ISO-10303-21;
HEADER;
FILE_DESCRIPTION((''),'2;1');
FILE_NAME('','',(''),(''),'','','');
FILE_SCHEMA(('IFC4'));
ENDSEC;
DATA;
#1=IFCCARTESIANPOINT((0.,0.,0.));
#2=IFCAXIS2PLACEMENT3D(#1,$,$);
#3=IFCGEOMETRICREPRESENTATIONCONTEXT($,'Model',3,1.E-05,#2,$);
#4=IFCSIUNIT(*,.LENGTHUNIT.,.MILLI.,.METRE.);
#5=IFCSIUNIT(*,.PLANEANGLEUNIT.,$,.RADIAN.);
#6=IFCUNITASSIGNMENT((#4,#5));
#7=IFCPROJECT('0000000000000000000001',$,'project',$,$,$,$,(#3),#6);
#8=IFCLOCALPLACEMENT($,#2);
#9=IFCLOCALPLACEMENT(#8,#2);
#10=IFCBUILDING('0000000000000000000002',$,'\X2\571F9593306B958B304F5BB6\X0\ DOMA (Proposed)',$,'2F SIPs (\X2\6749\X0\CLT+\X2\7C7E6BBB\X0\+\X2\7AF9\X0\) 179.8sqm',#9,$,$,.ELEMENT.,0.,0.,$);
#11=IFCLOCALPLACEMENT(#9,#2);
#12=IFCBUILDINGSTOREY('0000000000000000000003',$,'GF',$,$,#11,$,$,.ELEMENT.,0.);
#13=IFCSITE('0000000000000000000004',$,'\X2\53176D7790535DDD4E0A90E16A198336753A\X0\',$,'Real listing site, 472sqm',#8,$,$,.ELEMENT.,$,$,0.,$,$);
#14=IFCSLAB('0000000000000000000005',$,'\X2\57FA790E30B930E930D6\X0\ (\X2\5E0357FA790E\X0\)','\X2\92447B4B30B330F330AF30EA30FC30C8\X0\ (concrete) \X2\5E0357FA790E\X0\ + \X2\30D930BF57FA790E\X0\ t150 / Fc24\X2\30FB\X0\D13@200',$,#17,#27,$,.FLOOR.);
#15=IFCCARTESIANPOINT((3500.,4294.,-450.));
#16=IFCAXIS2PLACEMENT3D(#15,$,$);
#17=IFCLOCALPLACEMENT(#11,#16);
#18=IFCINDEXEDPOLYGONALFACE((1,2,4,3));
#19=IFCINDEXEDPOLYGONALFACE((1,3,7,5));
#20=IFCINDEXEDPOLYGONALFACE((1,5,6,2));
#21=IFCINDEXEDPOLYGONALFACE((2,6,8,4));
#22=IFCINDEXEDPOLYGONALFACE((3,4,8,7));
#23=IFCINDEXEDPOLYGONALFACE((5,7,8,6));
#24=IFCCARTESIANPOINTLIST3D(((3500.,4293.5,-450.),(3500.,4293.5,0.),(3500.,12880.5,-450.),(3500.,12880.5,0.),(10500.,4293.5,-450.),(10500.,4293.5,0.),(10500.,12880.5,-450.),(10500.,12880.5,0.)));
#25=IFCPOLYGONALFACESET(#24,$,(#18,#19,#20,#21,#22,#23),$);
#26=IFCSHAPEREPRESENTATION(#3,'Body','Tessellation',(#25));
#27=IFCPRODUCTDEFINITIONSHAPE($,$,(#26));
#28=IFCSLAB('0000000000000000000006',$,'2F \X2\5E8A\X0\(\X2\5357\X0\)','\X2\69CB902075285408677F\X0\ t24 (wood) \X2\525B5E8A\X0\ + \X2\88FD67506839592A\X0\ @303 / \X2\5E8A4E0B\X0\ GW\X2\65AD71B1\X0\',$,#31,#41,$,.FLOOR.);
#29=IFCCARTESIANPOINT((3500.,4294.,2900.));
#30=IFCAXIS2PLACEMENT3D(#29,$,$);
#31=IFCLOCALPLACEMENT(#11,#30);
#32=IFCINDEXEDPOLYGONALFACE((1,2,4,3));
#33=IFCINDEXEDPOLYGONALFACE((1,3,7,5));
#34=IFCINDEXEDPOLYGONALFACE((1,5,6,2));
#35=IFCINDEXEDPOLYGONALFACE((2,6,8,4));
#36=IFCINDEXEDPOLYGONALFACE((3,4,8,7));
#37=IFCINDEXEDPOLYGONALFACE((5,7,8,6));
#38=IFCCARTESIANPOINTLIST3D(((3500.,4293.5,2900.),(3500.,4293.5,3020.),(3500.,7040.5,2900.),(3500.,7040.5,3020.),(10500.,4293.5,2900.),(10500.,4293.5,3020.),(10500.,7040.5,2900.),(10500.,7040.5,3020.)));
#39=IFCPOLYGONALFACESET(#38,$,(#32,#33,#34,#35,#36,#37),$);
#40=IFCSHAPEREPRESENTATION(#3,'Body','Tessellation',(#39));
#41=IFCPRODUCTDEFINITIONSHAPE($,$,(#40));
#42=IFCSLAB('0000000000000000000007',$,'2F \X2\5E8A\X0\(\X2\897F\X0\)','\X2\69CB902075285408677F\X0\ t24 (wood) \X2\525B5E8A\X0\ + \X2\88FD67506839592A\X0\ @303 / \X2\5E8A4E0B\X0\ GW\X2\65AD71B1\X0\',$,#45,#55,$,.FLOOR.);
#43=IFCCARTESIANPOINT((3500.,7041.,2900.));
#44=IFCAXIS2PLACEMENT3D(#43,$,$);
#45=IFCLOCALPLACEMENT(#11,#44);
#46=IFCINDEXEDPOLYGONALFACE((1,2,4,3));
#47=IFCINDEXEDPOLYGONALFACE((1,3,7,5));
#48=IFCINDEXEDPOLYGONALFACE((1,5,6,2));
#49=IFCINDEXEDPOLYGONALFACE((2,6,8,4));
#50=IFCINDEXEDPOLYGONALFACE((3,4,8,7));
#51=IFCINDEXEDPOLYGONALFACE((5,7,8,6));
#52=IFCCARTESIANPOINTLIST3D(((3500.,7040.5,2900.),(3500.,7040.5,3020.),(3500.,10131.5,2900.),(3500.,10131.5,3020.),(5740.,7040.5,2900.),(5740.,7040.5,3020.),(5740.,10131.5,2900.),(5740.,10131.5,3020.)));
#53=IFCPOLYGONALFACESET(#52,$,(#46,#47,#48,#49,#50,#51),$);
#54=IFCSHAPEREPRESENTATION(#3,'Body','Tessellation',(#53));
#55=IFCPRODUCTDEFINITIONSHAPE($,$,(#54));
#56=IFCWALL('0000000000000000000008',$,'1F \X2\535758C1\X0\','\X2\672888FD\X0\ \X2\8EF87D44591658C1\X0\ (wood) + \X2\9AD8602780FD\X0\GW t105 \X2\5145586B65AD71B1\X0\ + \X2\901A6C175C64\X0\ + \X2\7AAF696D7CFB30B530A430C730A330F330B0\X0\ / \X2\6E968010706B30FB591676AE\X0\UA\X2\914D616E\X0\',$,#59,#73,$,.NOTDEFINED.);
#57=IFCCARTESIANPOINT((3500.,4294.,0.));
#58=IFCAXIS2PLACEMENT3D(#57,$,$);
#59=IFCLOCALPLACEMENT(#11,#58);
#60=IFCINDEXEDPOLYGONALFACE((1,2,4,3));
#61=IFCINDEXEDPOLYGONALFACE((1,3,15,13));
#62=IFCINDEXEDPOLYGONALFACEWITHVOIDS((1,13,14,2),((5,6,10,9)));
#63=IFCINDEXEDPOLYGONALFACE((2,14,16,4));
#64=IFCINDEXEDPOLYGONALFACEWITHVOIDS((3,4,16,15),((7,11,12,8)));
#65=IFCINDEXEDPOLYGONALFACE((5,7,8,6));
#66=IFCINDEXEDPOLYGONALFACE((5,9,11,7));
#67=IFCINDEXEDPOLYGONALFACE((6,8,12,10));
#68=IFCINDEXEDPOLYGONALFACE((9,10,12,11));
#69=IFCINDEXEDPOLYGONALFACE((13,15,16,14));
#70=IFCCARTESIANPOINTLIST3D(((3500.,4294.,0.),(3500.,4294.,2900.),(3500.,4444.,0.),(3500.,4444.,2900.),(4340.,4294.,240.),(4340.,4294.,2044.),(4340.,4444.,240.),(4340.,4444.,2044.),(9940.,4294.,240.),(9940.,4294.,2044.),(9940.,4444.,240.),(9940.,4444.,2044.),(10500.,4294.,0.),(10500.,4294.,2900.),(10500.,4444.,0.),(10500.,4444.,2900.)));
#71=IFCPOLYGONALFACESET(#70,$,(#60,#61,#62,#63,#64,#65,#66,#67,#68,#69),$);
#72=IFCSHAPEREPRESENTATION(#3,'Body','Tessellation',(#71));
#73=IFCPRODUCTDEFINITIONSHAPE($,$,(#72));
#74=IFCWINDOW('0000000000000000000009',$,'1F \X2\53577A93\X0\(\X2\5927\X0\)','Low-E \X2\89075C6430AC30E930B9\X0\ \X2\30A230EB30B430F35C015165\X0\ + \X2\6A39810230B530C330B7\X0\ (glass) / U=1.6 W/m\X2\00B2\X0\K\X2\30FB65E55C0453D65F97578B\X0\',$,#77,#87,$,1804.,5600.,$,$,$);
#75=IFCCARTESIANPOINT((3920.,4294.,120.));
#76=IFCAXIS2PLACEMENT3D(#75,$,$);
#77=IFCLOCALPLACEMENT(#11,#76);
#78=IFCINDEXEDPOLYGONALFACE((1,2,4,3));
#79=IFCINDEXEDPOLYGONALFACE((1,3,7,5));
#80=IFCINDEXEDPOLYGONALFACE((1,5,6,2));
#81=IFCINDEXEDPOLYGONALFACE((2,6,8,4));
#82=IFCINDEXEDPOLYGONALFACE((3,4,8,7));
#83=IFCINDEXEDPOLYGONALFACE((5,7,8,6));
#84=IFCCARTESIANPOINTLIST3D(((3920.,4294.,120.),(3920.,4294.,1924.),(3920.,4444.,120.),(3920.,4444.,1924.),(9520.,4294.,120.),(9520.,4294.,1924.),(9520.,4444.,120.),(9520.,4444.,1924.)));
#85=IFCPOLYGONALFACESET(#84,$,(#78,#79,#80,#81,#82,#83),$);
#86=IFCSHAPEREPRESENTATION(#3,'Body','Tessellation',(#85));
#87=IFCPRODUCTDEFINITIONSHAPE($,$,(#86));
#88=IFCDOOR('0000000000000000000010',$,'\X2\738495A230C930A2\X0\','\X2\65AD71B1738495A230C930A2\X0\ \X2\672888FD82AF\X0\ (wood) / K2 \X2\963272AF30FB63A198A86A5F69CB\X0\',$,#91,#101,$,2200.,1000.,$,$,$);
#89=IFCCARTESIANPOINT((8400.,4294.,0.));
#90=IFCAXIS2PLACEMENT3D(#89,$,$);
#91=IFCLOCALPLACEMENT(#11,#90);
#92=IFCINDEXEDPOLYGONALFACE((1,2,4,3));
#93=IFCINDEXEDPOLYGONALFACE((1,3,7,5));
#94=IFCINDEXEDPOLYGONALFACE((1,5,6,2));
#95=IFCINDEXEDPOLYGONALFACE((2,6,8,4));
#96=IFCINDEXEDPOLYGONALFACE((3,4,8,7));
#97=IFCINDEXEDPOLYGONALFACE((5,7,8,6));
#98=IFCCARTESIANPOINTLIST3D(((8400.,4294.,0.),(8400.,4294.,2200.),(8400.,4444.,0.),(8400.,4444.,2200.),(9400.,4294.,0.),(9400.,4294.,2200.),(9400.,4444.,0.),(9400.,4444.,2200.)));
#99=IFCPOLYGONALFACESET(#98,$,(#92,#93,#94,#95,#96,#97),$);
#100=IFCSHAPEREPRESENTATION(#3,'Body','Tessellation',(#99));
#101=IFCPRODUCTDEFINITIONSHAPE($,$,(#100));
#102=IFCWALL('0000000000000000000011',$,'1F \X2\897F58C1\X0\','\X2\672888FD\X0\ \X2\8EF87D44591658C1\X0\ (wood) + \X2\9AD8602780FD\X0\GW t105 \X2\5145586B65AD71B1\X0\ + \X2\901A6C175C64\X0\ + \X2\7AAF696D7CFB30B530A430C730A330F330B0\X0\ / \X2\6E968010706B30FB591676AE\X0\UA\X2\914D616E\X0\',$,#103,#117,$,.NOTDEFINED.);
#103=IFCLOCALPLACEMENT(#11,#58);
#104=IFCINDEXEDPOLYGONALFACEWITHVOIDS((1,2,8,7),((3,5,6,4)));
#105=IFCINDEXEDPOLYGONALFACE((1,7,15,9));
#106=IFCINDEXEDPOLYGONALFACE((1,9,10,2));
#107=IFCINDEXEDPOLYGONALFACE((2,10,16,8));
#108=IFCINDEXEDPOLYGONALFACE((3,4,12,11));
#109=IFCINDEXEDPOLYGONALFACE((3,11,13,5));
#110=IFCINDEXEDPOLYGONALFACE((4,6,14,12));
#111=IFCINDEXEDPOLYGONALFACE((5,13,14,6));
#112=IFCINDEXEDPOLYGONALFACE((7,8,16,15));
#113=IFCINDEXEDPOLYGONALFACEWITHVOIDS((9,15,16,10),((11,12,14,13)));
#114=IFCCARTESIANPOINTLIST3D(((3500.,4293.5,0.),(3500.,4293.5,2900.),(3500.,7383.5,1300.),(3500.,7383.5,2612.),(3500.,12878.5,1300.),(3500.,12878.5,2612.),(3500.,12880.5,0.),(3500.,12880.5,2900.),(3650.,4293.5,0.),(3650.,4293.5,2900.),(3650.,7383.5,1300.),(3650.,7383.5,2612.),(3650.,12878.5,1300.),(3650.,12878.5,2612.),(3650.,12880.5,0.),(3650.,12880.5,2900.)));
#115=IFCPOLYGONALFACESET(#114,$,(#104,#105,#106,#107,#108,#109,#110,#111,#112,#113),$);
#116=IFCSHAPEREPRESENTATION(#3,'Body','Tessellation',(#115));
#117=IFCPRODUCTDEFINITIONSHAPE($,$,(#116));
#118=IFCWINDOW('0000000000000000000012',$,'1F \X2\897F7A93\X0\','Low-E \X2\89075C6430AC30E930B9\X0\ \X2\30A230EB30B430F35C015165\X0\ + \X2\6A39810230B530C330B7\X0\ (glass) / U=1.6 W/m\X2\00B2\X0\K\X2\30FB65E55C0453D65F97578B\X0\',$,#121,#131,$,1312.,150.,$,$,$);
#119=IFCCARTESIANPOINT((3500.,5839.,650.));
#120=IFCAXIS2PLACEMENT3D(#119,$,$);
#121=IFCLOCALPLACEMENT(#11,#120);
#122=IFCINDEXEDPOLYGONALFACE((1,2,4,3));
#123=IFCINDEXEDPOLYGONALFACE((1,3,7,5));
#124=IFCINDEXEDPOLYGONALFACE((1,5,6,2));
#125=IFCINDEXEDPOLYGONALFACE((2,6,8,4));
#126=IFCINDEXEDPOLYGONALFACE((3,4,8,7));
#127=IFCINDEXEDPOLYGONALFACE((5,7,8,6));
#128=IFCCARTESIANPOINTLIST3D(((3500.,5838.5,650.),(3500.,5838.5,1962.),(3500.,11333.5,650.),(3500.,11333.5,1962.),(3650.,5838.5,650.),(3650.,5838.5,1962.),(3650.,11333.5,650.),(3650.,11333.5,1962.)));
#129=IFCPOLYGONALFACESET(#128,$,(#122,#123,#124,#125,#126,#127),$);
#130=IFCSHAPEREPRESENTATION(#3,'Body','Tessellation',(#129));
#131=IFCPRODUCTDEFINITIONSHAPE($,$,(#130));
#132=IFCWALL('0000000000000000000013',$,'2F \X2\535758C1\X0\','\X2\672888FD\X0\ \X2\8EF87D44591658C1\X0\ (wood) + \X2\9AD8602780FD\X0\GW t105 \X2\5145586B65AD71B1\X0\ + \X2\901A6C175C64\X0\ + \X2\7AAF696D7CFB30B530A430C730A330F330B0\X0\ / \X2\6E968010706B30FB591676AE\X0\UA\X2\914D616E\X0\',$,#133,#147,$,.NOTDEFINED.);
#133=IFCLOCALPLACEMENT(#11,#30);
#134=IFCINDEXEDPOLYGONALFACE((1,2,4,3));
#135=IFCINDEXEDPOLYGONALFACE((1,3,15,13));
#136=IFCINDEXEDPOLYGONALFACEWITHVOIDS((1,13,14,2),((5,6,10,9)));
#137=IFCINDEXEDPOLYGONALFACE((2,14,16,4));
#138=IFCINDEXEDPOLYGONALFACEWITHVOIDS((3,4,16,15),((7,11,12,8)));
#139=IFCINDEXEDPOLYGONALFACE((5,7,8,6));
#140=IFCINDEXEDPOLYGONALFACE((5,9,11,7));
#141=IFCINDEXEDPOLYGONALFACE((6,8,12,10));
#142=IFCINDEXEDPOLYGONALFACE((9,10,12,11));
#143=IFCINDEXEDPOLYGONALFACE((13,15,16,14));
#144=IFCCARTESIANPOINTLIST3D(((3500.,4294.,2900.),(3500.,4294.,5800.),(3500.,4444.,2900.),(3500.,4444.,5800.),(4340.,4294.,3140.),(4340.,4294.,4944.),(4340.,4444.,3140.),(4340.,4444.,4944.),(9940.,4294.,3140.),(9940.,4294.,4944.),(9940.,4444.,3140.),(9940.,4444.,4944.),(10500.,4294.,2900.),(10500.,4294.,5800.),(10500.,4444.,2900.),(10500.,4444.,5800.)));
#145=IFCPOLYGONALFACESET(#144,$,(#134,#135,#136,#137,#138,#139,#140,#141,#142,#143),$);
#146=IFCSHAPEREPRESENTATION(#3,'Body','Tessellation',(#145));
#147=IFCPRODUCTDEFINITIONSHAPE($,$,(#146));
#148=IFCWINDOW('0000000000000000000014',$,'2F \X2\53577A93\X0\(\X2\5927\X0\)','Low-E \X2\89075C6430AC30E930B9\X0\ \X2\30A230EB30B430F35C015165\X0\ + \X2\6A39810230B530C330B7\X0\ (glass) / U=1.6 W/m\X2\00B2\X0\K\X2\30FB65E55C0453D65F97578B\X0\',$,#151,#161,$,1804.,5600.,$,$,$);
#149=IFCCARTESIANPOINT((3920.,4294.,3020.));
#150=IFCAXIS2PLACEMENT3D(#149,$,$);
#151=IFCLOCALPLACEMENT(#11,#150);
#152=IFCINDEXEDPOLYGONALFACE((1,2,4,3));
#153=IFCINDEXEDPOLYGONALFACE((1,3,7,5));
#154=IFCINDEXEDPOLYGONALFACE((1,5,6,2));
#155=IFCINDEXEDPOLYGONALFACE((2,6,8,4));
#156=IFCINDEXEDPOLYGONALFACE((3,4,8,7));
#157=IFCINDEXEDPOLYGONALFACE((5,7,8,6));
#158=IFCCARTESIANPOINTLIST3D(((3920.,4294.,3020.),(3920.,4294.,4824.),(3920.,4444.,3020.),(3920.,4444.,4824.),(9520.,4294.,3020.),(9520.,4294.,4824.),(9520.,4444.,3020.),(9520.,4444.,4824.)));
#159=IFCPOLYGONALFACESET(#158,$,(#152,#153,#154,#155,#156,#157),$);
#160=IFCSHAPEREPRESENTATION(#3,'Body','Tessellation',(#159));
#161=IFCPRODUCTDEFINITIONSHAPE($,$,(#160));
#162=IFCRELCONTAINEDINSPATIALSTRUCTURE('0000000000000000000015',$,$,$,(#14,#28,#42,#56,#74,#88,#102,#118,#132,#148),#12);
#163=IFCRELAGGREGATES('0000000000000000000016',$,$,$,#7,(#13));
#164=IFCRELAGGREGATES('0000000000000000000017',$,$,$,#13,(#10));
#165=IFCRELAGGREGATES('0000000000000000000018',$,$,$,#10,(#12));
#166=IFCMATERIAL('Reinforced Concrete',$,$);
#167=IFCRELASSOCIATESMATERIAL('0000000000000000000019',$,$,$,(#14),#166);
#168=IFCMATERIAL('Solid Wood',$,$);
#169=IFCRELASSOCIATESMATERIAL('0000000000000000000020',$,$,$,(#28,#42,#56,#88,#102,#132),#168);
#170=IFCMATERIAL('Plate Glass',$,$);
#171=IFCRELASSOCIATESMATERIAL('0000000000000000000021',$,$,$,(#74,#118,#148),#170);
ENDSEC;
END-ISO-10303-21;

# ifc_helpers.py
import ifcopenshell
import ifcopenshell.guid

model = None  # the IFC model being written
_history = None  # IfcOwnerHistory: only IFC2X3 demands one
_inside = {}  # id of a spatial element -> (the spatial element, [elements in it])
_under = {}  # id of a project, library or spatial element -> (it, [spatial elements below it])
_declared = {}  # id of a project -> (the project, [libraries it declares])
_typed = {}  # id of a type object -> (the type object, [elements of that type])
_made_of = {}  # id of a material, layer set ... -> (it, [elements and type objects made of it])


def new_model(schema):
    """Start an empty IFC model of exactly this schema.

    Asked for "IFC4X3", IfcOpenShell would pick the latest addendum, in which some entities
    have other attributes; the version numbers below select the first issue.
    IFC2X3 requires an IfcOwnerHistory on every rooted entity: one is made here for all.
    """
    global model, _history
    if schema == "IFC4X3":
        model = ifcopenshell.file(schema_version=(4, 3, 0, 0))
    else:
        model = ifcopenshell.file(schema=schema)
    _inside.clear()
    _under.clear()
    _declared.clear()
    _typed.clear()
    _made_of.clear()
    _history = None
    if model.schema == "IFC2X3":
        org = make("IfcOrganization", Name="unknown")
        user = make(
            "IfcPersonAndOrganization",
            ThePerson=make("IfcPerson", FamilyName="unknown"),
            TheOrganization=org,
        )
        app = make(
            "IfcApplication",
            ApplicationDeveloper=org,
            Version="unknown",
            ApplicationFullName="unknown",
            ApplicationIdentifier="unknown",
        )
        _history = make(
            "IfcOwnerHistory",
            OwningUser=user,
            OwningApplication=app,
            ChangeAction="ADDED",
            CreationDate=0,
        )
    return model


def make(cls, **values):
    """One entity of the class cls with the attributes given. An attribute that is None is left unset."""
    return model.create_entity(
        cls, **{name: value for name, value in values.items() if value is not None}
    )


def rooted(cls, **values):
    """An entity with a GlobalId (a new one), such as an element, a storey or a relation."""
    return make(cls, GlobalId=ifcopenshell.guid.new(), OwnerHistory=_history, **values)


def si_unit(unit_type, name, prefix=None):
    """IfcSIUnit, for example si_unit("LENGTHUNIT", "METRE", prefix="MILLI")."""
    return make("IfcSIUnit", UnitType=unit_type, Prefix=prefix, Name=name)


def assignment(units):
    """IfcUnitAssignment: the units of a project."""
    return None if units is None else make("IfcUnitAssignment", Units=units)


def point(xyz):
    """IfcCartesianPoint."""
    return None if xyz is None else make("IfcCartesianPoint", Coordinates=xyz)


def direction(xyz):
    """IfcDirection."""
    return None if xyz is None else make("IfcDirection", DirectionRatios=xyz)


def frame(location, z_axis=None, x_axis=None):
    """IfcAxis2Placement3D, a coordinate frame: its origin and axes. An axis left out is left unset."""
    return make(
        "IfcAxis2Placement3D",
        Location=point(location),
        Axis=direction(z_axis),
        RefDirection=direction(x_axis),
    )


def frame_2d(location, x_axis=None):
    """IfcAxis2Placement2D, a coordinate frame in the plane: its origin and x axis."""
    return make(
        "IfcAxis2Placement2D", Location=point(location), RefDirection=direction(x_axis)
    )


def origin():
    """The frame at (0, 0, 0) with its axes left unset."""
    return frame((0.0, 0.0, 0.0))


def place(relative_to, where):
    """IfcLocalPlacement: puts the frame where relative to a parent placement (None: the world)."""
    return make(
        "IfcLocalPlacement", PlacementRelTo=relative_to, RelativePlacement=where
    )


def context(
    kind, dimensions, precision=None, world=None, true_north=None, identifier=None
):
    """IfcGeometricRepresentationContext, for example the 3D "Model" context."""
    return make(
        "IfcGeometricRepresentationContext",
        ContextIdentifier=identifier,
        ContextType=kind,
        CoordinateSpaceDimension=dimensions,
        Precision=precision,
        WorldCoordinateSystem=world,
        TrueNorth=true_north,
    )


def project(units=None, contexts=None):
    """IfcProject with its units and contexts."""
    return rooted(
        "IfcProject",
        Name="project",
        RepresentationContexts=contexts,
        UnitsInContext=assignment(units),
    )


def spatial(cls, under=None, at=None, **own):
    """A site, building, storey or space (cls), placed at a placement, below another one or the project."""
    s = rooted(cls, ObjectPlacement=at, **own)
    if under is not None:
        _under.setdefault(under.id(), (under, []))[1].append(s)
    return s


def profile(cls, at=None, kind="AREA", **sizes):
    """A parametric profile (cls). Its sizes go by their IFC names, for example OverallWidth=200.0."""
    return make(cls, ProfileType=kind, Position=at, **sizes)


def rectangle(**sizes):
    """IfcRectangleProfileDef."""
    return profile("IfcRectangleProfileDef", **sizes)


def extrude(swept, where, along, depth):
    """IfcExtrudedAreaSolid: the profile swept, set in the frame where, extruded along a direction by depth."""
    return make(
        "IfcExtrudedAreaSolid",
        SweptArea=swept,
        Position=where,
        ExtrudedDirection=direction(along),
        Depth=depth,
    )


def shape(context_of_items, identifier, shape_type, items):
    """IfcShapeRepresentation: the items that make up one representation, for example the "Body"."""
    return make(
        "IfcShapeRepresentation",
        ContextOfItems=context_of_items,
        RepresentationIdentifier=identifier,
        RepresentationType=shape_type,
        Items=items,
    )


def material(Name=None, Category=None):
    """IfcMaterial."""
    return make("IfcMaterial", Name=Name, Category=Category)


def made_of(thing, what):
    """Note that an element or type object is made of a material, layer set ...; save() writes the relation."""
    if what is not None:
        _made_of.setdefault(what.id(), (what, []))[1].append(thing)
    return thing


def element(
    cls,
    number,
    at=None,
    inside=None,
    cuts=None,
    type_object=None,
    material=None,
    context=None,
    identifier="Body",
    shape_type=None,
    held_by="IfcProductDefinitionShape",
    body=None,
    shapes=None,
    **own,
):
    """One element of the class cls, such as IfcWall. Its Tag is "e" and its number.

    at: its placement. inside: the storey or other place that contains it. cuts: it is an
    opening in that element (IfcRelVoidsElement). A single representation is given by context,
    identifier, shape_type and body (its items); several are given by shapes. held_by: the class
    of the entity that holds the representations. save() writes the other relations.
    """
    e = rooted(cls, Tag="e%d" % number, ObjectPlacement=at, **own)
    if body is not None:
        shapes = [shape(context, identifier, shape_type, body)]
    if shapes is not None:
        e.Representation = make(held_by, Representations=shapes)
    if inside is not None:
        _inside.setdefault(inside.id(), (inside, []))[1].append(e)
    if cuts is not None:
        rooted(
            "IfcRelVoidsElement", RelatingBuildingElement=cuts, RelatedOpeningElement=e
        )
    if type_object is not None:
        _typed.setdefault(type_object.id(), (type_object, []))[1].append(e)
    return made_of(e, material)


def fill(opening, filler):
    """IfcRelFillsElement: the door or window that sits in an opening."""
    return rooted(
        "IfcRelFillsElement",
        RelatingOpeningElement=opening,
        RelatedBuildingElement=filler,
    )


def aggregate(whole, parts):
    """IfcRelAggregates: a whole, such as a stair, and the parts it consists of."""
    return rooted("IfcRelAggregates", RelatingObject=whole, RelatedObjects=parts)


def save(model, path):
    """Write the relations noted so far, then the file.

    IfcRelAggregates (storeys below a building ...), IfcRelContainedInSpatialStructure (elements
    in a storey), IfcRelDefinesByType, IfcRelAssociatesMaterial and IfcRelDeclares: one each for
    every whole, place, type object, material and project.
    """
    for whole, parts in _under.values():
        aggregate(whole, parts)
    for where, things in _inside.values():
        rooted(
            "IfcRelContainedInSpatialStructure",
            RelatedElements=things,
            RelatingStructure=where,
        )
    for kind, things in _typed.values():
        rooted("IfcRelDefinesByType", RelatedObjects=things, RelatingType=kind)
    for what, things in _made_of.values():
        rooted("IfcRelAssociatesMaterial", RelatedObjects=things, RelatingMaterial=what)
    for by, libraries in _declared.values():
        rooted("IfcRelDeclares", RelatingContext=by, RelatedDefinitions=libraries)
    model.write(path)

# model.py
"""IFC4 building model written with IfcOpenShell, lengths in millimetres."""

from ifc_helpers import new_model, si_unit, frame, frame_2d, origin, place, context, project, spatial, rectangle, extrude, material, element, fill, save


model = new_model("IFC4")

# Units and contexts
model_context = context("Model", 3, precision=1e-05, world=origin())
ifc_project = project(units=[si_unit("LENGTHUNIT", "METRE", prefix="MILLI"), si_unit("PLANEANGLEUNIT", "RADIAN")], contexts=[model_context])

# Site, building, storey
site_placement = place(None, origin())
site = spatial("IfcSite", under=ifc_project, at=site_placement, Name="北海道川上郡標茶町", ObjectType="Real listing site, 472sqm", CompositionType="ELEMENT", RefElevation=0.0)
building_placement = place(site_placement, origin())
building = spatial("IfcBuilding", under=site, at=building_placement, Name="土間に開く家 DOMA (Proposed)", ObjectType="2F SIPs (杉CLT+籾殻+竹) 179.8sqm", CompositionType="ELEMENT", ElevationOfRefHeight=0.0, ElevationOfTerrain=0.0)
storey_placement = place(building_placement, origin())
storey = spatial("IfcBuildingStorey", under=building, at=storey_placement, Name="GF", CompositionType="ELEMENT", Elevation=0.0)

# Slabs
ifc_material_1 = material(Name="Reinforced Concrete")
slab_1_placement = place(storey_placement, frame((3500.0, 4294.0, -450.0)))
element("IfcSlab", 1, at=slab_1_placement, inside=storey, material=ifc_material_1, Name="基礎スラブ (布基礎)", Description="鉄筋コンクリート (concrete) 布基礎 + ベタ基礎 t150 / Fc24・D13@200", PredefinedType="FLOOR", context=model_context, shape_type="SweptSolid", body=[
    extrude(rectangle(XDim=7000.0, YDim=8587.0, at=frame_2d((3500.0, 4293.0))), frame((3500.0, 4294.0, -450.0)), (0.0, 0.0, 1.0), 450.0),
])
ifc_material_2 = material(Name="Solid Wood")
slab_2_placement = place(storey_placement, frame((3500.0, 4294.0, 2900.0)))
element("IfcSlab", 2, at=slab_2_placement, inside=storey, material=ifc_material_2, Name="2F 床(南)", Description="構造用合板 t24 (wood) 剛床 + 製材根太 @303 / 床下 GW断熱", PredefinedType="FLOOR", context=model_context, shape_type="SweptSolid", body=[
    extrude(rectangle(XDim=7000.0, YDim=2747.0, at=frame_2d((3500.0, 1373.0))), frame((3500.0, 4294.0, 2900.0)), (0.0, 0.0, 1.0), 120.0),
])
slab_3_placement = place(storey_placement, frame((3500.0, 7041.0, 2900.0)))
element("IfcSlab", 3, at=slab_3_placement, inside=storey, material=ifc_material_2, Name="2F 床(西)", Description="構造用合板 t24 (wood) 剛床 + 製材根太 @303 / 床下 GW断熱", PredefinedType="FLOOR", context=model_context, shape_type="SweptSolid", body=[
    extrude(rectangle(XDim=2240.0, YDim=3091.0, at=frame_2d((1120.0, 1545.0))), frame((3500.0, 7041.0, 2900.0)), (0.0, 0.0, 1.0), 120.0),
])

# Wall, openings, window, door
wall_1_placement = place(storey_placement, frame((3500.0, 4294.0, 0.0)))
wall_1 = element("IfcWall", 4, at=wall_1_placement, inside=storey, material=ifc_material_2, Name="1F 南壁", Description="木製 軸組外壁 (wood) + 高性能GW t105 充填断熱 + 通気層 + 窯業系サイディング / 準耐火・外皮UA配慮", PredefinedType="NOTDEFINED", context=model_context, shape_type="SweptSolid", body=[
    extrude(rectangle(XDim=7000.0, YDim=150.0, at=frame_2d((3500.0, 75.0))), frame((3500.0, 4294.0, 0.0)), (0.0, 0.0, 1.0), 2900.0),
])
opening_1_placement = place(storey_placement, frame((3920.0, 4294.0, 120.0)))
opening_1 = element("IfcOpeningElement", 5, at=opening_1_placement, cuts=wall_1, PredefinedType="NOTDEFINED", context=model_context, shape_type="SweptSolid", body=[
    extrude(rectangle(XDim=5600.0, YDim=150.0, at=frame_2d((2800.0, 75.0))), frame((3920.0, 4294.0, 120.0)), (0.0, 0.0, 1.0), 1804.0),
])
opening_2_placement = place(storey_placement, frame((8400.0, 4294.0, 0.0)))
opening_2 = element("IfcOpeningElement", 6, at=opening_2_placement, cuts=wall_1, PredefinedType="NOTDEFINED", context=model_context, shape_type="SweptSolid", body=[
    extrude(rectangle(XDim=1000.0, YDim=150.0, at=frame_2d((500.0, 75.0))), frame((8400.0, 4294.0, 0.0)), (0.0, 0.0, 1.0), 2200.0),
])
ifc_material_3 = material(Name="Plate Glass")
window_1_placement = place(storey_placement, frame((3920.0, 4294.0, 120.0)))
window_1 = element("IfcWindow", 7, at=window_1_placement, inside=storey, material=ifc_material_3, Name="1F 南窓(大)", Description="Low-E 複層ガラス アルゴン封入 + 樹脂サッシ (glass) / U=1.6 W/m²K・日射取得型", OverallHeight=1804.0, OverallWidth=5600.0, context=model_context, shape_type="SweptSolid", body=[
    extrude(rectangle(XDim=5600.0, YDim=150.0, at=frame_2d((2800.0, 75.0))), frame((3920.0, 4294.0, 120.0)), (0.0, 0.0, 1.0), 1804.0),
])
fill(opening_1, window_1)
door_placement = place(storey_placement, frame((8400.0, 4294.0, 0.0)))
door = element("IfcDoor", 8, at=door_placement, inside=storey, material=ifc_material_2, Name="玄関ドア", Description="断熱玄関ドア 木製芯 (wood) / K2 防犯・採風機構", OverallHeight=2200.0, OverallWidth=1000.0, context=model_context, shape_type="SweptSolid", body=[
    extrude(rectangle(XDim=1000.0, YDim=150.0, at=frame_2d((500.0, 75.0))), frame((8400.0, 4294.0, 0.0)), (0.0, 0.0, 1.0), 2200.0),
])
fill(opening_2, door)

# Walls, openings, windows
wall_2_placement = place(storey_placement, frame((3500.0, 4294.0, 0.0)))
wall_2 = element("IfcWall", 9, at=wall_2_placement, inside=storey, material=ifc_material_2, Name="1F 西壁", Description="木製 軸組外壁 (wood) + 高性能GW t105 充填断熱 + 通気層 + 窯業系サイディング / 準耐火・外皮UA配慮", PredefinedType="NOTDEFINED", context=model_context, shape_type="SweptSolid", body=[
    extrude(rectangle(XDim=150.0, YDim=8587.0, at=frame_2d((75.0, 4293.0))), frame((3500.0, 4294.0, 0.0)), (0.0, 0.0, 1.0), 2900.0),
])
opening_3_placement = place(storey_placement, frame((3500.0, 5839.0, 650.0)))
opening_3 = element("IfcOpeningElement", 10, at=opening_3_placement, cuts=wall_2, PredefinedType="NOTDEFINED", context=model_context, shape_type="SweptSolid", body=[
    extrude(rectangle(XDim=150.0, YDim=5495.0, at=frame_2d((75.0, 2747.0))), frame((3500.0, 5839.0, 650.0)), (0.0, 0.0, 1.0), 1312.0),
])
window_2_placement = place(storey_placement, frame((3500.0, 5839.0, 650.0)))
window_2 = element("IfcWindow", 11, at=window_2_placement, inside=storey, material=ifc_material_3, Name="1F 西窓", Description="Low-E 複層ガラス アルゴン封入 + 樹脂サッシ (glass) / U=1.6 W/m²K・日射取得型", OverallHeight=1312.0, OverallWidth=150.0, context=model_context, shape_type="SweptSolid", body=[
    extrude(rectangle(XDim=150.0, YDim=5495.0, at=frame_2d((75.0, 2747.0))), frame((3500.0, 5839.0, 650.0)), (0.0, 0.0, 1.0), 1312.0),
])
fill(opening_3, window_2)
wall_3_placement = place(storey_placement, frame((3500.0, 4294.0, 2900.0)))
wall_3 = element("IfcWall", 12, at=wall_3_placement, inside=storey, material=ifc_material_2, Name="2F 南壁", Description="木製 軸組外壁 (wood) + 高性能GW t105 充填断熱 + 通気層 + 窯業系サイディング / 準耐火・外皮UA配慮", PredefinedType="NOTDEFINED", context=model_context, shape_type="SweptSolid", body=[
    extrude(rectangle(XDim=7000.0, YDim=150.0, at=frame_2d((3500.0, 75.0))), frame((3500.0, 4294.0, 2900.0)), (0.0, 0.0, 1.0), 2900.0),
])
opening_4_placement = place(storey_placement, frame((3920.0, 4294.0, 3020.0)))
opening_4 = element("IfcOpeningElement", 13, at=opening_4_placement, cuts=wall_3, PredefinedType="NOTDEFINED", context=model_context, shape_type="SweptSolid", body=[
    extrude(rectangle(XDim=5600.0, YDim=150.0, at=frame_2d((2800.0, 75.0))), frame((3920.0, 4294.0, 3020.0)), (0.0, 0.0, 1.0), 1804.0),
])
window_3_placement = place(storey_placement, frame((3920.0, 4294.0, 3020.0)))
window_3 = element("IfcWindow", 14, at=window_3_placement, inside=storey, material=ifc_material_3, Name="2F 南窓(大)", Description="Low-E 複層ガラス アルゴン封入 + 樹脂サッシ (glass) / U=1.6 W/m²K・日射取得型", OverallHeight=1804.0, OverallWidth=5600.0, context=model_context, shape_type="SweptSolid", body=[
    extrude(rectangle(XDim=5600.0, YDim=150.0, at=frame_2d((2800.0, 75.0))), frame((3920.0, 4294.0, 3020.0)), (0.0, 0.0, 1.0), 1804.0),
])
fill(opening_4, window_3)

save(model, "model.ifc")
